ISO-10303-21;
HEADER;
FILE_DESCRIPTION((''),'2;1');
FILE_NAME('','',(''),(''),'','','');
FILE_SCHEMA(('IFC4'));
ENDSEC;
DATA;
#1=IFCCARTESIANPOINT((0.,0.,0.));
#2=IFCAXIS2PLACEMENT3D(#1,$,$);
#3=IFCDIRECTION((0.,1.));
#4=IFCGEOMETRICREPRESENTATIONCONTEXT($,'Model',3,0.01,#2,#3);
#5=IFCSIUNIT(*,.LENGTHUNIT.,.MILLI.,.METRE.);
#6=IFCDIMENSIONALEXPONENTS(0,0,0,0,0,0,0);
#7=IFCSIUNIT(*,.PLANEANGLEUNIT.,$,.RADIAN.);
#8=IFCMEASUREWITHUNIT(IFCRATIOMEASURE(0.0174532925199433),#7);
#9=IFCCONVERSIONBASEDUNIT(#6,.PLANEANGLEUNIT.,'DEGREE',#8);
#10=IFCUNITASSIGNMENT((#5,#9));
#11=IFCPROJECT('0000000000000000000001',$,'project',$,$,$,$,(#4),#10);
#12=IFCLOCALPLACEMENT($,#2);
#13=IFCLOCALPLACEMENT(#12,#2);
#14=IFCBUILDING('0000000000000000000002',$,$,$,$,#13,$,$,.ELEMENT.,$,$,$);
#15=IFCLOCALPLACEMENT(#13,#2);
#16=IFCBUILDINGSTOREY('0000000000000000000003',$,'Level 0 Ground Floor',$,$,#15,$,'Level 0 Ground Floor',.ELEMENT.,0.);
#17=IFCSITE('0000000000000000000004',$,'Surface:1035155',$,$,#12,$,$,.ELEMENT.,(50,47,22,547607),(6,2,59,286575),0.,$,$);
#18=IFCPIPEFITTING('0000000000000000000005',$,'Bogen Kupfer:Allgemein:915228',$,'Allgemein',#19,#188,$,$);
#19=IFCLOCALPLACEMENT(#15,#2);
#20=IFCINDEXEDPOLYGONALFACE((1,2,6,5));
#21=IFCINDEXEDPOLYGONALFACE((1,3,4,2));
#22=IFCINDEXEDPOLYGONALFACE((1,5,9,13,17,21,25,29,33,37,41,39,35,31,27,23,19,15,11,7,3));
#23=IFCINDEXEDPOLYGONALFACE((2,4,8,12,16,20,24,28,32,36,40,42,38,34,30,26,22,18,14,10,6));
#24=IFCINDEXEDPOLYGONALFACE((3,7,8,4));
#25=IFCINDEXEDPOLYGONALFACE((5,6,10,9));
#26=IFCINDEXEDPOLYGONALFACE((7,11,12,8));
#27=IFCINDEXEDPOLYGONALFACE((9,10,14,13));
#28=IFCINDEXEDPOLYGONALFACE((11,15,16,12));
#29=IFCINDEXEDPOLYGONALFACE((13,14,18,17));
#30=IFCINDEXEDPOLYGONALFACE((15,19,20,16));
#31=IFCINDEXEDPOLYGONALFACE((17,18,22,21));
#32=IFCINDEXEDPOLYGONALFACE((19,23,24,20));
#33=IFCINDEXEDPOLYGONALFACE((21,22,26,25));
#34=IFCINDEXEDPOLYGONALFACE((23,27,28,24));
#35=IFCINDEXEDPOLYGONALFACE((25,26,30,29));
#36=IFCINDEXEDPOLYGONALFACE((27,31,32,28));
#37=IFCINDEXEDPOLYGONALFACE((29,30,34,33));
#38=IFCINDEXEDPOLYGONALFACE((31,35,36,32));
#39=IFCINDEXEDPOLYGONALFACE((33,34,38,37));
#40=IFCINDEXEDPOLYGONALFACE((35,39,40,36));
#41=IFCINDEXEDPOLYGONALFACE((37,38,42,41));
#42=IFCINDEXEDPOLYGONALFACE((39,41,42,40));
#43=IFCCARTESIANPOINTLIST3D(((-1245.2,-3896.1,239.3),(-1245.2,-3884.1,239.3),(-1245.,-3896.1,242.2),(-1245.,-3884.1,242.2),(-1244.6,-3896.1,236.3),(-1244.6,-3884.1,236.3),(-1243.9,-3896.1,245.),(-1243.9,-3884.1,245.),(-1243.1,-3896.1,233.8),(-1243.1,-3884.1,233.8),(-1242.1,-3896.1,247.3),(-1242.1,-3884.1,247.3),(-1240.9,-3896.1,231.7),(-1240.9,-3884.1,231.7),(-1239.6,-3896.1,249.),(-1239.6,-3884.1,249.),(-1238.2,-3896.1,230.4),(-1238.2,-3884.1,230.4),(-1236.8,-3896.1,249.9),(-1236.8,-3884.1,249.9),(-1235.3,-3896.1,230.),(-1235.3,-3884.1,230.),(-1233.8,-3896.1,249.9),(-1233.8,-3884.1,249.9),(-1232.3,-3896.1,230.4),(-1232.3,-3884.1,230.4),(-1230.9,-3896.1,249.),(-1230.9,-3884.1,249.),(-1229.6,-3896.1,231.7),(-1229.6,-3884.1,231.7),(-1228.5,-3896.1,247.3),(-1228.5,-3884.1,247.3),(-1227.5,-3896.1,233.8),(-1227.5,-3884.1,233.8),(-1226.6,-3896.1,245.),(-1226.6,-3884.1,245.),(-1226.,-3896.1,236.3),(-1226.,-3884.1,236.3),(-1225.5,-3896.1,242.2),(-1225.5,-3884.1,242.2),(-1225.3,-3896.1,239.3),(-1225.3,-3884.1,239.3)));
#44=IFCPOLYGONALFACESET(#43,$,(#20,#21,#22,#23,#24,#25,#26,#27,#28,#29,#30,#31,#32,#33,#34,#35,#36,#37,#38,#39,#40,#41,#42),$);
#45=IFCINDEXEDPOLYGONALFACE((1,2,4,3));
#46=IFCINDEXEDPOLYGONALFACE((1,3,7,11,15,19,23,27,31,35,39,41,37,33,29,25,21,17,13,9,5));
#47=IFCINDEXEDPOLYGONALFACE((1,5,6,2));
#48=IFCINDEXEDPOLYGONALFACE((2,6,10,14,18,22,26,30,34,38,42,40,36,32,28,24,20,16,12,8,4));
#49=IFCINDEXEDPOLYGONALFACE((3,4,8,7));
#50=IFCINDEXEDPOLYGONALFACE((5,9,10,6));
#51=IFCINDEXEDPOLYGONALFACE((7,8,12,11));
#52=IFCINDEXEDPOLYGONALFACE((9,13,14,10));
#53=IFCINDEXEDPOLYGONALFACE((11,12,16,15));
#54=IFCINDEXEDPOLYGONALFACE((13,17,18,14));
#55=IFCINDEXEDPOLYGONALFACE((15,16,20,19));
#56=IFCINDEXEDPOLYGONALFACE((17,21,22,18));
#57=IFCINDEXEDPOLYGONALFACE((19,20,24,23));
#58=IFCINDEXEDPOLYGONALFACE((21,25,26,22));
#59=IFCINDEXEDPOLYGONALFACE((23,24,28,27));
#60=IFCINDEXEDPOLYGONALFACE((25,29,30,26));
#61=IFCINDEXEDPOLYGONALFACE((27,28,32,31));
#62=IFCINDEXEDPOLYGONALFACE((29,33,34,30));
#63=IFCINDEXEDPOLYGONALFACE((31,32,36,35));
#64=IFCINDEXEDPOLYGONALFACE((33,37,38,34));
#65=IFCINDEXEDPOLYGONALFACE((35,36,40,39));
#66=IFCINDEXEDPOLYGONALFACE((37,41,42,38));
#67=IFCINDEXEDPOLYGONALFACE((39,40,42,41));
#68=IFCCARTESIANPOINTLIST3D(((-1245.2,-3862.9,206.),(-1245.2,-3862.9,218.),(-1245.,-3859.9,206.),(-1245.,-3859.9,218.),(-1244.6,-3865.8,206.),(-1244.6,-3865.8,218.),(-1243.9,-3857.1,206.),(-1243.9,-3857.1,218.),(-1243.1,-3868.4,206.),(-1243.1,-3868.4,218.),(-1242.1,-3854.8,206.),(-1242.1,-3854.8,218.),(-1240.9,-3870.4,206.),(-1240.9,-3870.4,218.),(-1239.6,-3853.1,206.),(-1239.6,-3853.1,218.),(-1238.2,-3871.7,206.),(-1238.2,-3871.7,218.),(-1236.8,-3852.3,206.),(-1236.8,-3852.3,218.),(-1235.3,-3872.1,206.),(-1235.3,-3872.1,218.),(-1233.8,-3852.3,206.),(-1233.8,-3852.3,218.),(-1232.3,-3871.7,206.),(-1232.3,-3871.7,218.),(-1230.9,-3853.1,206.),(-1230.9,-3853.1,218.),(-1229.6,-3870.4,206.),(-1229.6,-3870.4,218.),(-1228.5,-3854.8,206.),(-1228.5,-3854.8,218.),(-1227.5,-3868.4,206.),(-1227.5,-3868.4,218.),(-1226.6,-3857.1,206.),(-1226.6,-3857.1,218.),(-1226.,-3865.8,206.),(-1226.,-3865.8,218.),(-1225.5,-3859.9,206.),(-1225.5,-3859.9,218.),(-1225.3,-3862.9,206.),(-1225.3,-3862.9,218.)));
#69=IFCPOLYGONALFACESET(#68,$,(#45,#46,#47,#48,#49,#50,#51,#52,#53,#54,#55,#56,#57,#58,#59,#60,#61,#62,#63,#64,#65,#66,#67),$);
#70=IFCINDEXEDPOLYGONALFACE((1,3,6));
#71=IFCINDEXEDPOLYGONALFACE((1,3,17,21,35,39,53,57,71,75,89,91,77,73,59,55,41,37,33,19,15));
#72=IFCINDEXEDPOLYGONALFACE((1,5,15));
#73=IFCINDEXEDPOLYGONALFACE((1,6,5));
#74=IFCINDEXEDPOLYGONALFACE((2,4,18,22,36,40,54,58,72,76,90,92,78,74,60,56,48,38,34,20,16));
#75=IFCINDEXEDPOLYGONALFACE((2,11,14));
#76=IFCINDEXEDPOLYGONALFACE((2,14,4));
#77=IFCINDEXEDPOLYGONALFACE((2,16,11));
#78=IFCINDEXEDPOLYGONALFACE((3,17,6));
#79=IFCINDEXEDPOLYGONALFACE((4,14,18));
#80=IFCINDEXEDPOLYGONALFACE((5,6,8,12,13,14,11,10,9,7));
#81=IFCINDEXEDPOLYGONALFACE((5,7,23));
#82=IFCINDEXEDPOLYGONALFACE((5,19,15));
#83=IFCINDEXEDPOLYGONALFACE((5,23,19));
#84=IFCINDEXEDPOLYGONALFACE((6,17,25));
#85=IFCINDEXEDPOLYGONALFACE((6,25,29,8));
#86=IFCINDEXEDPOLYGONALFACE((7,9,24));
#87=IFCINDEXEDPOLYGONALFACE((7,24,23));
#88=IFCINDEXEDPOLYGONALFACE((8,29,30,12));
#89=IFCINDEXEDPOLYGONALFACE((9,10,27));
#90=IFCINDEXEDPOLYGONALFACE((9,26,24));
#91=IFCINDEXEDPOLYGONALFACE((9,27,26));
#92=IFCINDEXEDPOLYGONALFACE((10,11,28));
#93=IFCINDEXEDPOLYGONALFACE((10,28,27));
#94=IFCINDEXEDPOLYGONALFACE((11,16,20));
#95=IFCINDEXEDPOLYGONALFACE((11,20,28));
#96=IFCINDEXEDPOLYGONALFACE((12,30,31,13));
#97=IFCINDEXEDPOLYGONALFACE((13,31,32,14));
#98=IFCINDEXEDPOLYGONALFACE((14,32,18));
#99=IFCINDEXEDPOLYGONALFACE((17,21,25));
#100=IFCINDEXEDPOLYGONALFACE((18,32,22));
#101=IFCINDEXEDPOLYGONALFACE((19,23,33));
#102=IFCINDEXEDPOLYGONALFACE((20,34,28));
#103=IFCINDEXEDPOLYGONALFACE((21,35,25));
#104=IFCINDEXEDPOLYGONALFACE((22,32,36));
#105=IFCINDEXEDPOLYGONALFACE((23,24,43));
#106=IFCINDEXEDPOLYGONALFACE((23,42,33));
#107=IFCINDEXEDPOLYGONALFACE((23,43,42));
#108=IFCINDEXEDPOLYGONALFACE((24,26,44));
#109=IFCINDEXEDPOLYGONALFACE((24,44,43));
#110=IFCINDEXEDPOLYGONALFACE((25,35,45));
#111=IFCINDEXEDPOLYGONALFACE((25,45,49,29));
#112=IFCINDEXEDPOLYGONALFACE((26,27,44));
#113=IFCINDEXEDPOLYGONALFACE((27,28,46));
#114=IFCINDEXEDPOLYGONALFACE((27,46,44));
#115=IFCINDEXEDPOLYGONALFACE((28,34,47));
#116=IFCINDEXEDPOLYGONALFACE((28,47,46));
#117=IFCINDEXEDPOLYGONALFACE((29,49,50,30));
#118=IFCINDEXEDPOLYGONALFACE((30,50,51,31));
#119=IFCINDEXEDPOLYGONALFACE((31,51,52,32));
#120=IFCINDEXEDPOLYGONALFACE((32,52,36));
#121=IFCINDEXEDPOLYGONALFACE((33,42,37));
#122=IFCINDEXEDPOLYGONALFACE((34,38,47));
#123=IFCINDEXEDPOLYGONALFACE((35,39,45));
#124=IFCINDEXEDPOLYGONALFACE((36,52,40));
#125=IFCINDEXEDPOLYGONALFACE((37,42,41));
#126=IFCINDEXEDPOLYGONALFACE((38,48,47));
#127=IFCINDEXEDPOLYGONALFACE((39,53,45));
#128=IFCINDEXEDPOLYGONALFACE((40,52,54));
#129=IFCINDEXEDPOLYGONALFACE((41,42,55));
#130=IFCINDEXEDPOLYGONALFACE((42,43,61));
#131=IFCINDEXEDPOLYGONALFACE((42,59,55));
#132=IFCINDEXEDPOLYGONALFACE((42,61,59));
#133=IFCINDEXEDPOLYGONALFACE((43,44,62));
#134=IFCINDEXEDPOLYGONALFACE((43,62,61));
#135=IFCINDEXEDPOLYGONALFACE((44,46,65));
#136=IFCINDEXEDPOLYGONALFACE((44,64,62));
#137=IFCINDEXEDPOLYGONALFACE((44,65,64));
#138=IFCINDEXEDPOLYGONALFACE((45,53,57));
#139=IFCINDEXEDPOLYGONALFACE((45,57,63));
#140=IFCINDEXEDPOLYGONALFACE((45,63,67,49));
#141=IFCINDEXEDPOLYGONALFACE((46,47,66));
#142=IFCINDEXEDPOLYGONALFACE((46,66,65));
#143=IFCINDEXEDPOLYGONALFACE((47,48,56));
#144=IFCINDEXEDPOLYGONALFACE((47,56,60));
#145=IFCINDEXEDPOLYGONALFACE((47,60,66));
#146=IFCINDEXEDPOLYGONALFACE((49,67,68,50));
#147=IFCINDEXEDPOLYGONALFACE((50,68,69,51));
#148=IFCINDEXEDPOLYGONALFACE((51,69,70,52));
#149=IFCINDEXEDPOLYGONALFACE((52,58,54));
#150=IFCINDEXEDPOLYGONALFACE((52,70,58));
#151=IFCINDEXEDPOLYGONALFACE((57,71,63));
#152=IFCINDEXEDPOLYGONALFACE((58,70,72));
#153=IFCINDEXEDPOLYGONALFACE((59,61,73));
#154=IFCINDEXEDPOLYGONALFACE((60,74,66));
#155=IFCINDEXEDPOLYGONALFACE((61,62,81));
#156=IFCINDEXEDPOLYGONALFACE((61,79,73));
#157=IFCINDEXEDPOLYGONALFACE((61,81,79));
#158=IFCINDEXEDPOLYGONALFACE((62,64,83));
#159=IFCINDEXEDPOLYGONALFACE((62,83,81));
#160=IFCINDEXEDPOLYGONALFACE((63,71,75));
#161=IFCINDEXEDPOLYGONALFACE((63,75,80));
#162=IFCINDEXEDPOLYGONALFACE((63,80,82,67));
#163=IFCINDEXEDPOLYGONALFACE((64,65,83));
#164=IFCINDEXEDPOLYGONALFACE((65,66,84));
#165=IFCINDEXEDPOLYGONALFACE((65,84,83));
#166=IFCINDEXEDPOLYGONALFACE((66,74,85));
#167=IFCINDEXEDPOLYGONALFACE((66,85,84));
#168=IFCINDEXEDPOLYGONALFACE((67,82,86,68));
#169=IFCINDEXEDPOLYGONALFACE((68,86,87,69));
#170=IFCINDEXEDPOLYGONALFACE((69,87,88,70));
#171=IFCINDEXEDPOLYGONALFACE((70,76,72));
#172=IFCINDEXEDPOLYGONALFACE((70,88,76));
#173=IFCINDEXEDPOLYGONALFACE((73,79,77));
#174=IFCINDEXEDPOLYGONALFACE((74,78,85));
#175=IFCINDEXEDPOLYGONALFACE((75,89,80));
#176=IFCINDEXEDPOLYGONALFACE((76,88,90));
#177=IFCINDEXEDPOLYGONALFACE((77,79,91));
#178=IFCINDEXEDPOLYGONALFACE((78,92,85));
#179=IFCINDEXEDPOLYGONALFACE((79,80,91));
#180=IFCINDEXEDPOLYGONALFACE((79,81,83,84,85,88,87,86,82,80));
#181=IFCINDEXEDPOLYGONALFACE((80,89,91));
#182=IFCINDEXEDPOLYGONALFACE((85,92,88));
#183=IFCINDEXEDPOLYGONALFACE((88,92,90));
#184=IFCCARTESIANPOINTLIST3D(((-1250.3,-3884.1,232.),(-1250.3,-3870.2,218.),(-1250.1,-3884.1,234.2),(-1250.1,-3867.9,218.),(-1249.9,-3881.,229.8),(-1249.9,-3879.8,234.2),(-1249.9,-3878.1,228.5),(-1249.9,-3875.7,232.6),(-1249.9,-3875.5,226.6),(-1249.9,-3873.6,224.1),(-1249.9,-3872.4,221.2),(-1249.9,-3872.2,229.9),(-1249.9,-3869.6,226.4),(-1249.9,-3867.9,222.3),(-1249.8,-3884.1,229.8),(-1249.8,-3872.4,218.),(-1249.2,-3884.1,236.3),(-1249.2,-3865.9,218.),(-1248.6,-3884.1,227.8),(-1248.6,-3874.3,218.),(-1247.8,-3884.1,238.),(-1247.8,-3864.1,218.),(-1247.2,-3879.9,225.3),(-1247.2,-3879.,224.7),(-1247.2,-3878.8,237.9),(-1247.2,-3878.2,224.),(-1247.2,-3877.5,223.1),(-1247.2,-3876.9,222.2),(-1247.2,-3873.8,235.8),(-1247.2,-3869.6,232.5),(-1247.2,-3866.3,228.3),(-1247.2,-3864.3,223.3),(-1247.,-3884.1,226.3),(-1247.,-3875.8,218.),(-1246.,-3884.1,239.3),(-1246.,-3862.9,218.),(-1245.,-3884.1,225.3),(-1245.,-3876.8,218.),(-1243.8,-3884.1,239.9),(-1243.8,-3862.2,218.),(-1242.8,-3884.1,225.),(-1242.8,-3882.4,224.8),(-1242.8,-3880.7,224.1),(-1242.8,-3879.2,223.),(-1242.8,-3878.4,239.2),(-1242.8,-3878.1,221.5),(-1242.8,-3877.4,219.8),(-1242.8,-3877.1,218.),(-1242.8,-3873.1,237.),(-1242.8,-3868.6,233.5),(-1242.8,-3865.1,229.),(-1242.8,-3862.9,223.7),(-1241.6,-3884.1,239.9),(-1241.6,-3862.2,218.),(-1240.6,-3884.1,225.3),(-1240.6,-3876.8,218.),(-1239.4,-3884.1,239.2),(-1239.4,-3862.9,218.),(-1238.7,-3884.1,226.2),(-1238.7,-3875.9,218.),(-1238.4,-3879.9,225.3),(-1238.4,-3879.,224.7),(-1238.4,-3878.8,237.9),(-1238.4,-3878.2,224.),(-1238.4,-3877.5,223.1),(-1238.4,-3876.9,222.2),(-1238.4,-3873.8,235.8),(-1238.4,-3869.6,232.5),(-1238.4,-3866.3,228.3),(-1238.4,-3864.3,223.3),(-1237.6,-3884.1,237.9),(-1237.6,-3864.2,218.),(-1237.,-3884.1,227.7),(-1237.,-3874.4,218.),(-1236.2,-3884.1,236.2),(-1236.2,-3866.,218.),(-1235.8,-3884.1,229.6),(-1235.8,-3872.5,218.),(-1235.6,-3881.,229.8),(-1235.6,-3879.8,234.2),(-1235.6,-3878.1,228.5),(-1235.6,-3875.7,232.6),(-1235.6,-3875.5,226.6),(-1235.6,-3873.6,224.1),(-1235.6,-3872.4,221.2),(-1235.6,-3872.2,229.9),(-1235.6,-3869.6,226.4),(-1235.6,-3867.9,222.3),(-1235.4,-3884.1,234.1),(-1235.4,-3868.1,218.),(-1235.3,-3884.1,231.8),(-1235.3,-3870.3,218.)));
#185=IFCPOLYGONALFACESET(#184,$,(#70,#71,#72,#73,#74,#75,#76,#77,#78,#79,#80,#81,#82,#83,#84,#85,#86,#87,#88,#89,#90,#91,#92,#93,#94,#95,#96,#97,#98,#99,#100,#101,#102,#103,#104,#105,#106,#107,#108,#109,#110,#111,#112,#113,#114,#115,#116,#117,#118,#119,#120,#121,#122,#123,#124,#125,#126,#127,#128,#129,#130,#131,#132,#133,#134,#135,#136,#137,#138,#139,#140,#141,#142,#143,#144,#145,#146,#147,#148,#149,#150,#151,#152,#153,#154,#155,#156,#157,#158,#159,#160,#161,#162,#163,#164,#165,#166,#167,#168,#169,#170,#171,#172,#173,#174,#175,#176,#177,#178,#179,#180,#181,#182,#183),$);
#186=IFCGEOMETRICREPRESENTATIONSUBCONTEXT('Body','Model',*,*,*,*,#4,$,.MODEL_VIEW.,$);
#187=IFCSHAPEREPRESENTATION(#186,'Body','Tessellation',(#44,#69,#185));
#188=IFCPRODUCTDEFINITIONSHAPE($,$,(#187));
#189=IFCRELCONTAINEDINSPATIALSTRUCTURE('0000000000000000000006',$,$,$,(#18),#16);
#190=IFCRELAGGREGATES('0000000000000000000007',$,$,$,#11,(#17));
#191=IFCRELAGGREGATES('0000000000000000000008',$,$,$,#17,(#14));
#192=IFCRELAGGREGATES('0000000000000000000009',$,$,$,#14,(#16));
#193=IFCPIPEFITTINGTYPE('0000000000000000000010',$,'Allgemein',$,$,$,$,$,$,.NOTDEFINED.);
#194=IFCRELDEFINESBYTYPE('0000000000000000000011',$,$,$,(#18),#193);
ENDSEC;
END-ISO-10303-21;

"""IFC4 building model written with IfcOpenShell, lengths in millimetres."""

from ifc_helpers import new_model, entity, si_unit, converted_unit, direction, frame, frame_2d, origin, place, context, subcontext, project, spatial, circle, extrude, source, transform, mapped, type_object, type_shapes, element, save


model = new_model("IFC4")

# Units and contexts
model_context = context("Model", 3, precision=0.01, world=origin(), true_north=direction((0.0, 1.0)))
body_context = subcontext(model_context, "Body", "Model", "MODEL_VIEW")
ifc_project = project(units=[si_unit("LENGTHUNIT", "METRE", prefix="MILLI"), converted_unit("PLANEANGLEUNIT", "DEGREE", entity("IfcRatioMeasure", 0.0174532925199433), si_unit("PLANEANGLEUNIT", "RADIAN"), dimensions=[0, 0, 0, 0, 0, 0, 0])], contexts=[model_context])

# Site, building, storey
site_placement = place(None, origin())
site = spatial("IfcSite", under=ifc_project, at=site_placement, Name="Surface:1035155", CompositionType="ELEMENT", RefLatitude=(50, 47, 22, 547607), RefLongitude=(6, 2, 59, 286575), RefElevation=0.0)
building_placement = place(site_placement, origin())
building = spatial("IfcBuilding", under=site, at=building_placement, CompositionType="ELEMENT")
storey_placement = place(building_placement, origin())
storey = spatial("IfcBuildingStorey", under=building, at=storey_placement, Name="Level 0 Ground Floor", LongName="Level 0 Ground Floor", CompositionType="ELEMENT", Elevation=0.0)

# Pipe fitting
pipe_fitting_type = type_object("IfcPipeFittingType", Name="Allgemein", PredefinedType="NOTDEFINED")
ifc_direction = entity("IfcDirection", [0.0, 0.0, -1.0])
trimmed_curve = entity("IfcTrimmedCurve", entity("IfcCircle", entity("IfcAxis2Placement2D", entity("IfcCartesianPoint", [-14.5, 0.0]), entity("IfcDirection", [0.0, 1.0])), 14.5), [entity("IfcParameterValue", 270.0)], [entity("IfcParameterValue", 0.0)], True, "PARAMETER")
shared_shape_1 = source(origin(), body_context, "Body", "SolidModel", [
    extrude(circle(Radius=10.0, at=frame_2d((0.0, 0.0), x_axis=(1.0, 0.0))), frame((0.0, 22.0, 0.0), z_axis=(0.0, 1.0, 0.0), x_axis=(-1.0, 0.0, 0.0)), (0.0, 0.0, 1.0), 12.0),
    extrude(circle(Radius=10.0, at=frame_2d((0.0, 0.0), x_axis=(1.0, 0.0))), frame((-34.0, 0.0, 0.0), z_axis=(1.0, 0.0, 0.0), x_axis=(0.0, 1.0, 0.0)), (0.0, 0.0, 1.0), 12.0),
    entity("IfcSurfaceCurveSweptAreaSolid", entity("IfcCircleProfileDef", "AREA", None, entity("IfcAxis2Placement2D", entity("IfcCartesianPoint", [0.0, 7.5]), entity("IfcDirection", [1.0, 0.0])), 7.5), entity("IfcAxis2Placement3D", entity("IfcCartesianPoint", [-7.5, 22.0, 0.0]), ifc_direction, entity("IfcDirection", [1.0, 0.0, 0.0])), trimmed_curve, 0.0, 90.0, entity("IfcSurfaceOfLinearExtrusion", entity("IfcArbitraryOpenProfileDef", "CURVE", None, trimmed_curve), entity("IfcAxis2Placement3D", entity("IfcCartesianPoint", [0.0, 0.0, -304.8])), ifc_direction, 1.0)),
])
type_shapes(pipe_fitting_type, [shared_shape_1])
for number, where, z_axis, x_axis, name in (
    (1, (-1235.3, -3862.1, 240.0), (1.0, 0.0, 0.0), (0.0, 0.0, 1.0), "Bogen Kupfer:Allgemein:915228"),
):
    element("IfcPipeFitting", number, at=place(storey_placement, frame(where, z_axis=z_axis, x_axis=x_axis)), inside=storey, type_object=pipe_fitting_type, Name=name, ObjectType="Allgemein", context=body_context, shape_type="MappedRepresentation", body=[
        mapped(shared_shape_1, transform((0.0, 0.0, 0.0), scale=1.0)),
    ])

save(model, "model.ifc")
